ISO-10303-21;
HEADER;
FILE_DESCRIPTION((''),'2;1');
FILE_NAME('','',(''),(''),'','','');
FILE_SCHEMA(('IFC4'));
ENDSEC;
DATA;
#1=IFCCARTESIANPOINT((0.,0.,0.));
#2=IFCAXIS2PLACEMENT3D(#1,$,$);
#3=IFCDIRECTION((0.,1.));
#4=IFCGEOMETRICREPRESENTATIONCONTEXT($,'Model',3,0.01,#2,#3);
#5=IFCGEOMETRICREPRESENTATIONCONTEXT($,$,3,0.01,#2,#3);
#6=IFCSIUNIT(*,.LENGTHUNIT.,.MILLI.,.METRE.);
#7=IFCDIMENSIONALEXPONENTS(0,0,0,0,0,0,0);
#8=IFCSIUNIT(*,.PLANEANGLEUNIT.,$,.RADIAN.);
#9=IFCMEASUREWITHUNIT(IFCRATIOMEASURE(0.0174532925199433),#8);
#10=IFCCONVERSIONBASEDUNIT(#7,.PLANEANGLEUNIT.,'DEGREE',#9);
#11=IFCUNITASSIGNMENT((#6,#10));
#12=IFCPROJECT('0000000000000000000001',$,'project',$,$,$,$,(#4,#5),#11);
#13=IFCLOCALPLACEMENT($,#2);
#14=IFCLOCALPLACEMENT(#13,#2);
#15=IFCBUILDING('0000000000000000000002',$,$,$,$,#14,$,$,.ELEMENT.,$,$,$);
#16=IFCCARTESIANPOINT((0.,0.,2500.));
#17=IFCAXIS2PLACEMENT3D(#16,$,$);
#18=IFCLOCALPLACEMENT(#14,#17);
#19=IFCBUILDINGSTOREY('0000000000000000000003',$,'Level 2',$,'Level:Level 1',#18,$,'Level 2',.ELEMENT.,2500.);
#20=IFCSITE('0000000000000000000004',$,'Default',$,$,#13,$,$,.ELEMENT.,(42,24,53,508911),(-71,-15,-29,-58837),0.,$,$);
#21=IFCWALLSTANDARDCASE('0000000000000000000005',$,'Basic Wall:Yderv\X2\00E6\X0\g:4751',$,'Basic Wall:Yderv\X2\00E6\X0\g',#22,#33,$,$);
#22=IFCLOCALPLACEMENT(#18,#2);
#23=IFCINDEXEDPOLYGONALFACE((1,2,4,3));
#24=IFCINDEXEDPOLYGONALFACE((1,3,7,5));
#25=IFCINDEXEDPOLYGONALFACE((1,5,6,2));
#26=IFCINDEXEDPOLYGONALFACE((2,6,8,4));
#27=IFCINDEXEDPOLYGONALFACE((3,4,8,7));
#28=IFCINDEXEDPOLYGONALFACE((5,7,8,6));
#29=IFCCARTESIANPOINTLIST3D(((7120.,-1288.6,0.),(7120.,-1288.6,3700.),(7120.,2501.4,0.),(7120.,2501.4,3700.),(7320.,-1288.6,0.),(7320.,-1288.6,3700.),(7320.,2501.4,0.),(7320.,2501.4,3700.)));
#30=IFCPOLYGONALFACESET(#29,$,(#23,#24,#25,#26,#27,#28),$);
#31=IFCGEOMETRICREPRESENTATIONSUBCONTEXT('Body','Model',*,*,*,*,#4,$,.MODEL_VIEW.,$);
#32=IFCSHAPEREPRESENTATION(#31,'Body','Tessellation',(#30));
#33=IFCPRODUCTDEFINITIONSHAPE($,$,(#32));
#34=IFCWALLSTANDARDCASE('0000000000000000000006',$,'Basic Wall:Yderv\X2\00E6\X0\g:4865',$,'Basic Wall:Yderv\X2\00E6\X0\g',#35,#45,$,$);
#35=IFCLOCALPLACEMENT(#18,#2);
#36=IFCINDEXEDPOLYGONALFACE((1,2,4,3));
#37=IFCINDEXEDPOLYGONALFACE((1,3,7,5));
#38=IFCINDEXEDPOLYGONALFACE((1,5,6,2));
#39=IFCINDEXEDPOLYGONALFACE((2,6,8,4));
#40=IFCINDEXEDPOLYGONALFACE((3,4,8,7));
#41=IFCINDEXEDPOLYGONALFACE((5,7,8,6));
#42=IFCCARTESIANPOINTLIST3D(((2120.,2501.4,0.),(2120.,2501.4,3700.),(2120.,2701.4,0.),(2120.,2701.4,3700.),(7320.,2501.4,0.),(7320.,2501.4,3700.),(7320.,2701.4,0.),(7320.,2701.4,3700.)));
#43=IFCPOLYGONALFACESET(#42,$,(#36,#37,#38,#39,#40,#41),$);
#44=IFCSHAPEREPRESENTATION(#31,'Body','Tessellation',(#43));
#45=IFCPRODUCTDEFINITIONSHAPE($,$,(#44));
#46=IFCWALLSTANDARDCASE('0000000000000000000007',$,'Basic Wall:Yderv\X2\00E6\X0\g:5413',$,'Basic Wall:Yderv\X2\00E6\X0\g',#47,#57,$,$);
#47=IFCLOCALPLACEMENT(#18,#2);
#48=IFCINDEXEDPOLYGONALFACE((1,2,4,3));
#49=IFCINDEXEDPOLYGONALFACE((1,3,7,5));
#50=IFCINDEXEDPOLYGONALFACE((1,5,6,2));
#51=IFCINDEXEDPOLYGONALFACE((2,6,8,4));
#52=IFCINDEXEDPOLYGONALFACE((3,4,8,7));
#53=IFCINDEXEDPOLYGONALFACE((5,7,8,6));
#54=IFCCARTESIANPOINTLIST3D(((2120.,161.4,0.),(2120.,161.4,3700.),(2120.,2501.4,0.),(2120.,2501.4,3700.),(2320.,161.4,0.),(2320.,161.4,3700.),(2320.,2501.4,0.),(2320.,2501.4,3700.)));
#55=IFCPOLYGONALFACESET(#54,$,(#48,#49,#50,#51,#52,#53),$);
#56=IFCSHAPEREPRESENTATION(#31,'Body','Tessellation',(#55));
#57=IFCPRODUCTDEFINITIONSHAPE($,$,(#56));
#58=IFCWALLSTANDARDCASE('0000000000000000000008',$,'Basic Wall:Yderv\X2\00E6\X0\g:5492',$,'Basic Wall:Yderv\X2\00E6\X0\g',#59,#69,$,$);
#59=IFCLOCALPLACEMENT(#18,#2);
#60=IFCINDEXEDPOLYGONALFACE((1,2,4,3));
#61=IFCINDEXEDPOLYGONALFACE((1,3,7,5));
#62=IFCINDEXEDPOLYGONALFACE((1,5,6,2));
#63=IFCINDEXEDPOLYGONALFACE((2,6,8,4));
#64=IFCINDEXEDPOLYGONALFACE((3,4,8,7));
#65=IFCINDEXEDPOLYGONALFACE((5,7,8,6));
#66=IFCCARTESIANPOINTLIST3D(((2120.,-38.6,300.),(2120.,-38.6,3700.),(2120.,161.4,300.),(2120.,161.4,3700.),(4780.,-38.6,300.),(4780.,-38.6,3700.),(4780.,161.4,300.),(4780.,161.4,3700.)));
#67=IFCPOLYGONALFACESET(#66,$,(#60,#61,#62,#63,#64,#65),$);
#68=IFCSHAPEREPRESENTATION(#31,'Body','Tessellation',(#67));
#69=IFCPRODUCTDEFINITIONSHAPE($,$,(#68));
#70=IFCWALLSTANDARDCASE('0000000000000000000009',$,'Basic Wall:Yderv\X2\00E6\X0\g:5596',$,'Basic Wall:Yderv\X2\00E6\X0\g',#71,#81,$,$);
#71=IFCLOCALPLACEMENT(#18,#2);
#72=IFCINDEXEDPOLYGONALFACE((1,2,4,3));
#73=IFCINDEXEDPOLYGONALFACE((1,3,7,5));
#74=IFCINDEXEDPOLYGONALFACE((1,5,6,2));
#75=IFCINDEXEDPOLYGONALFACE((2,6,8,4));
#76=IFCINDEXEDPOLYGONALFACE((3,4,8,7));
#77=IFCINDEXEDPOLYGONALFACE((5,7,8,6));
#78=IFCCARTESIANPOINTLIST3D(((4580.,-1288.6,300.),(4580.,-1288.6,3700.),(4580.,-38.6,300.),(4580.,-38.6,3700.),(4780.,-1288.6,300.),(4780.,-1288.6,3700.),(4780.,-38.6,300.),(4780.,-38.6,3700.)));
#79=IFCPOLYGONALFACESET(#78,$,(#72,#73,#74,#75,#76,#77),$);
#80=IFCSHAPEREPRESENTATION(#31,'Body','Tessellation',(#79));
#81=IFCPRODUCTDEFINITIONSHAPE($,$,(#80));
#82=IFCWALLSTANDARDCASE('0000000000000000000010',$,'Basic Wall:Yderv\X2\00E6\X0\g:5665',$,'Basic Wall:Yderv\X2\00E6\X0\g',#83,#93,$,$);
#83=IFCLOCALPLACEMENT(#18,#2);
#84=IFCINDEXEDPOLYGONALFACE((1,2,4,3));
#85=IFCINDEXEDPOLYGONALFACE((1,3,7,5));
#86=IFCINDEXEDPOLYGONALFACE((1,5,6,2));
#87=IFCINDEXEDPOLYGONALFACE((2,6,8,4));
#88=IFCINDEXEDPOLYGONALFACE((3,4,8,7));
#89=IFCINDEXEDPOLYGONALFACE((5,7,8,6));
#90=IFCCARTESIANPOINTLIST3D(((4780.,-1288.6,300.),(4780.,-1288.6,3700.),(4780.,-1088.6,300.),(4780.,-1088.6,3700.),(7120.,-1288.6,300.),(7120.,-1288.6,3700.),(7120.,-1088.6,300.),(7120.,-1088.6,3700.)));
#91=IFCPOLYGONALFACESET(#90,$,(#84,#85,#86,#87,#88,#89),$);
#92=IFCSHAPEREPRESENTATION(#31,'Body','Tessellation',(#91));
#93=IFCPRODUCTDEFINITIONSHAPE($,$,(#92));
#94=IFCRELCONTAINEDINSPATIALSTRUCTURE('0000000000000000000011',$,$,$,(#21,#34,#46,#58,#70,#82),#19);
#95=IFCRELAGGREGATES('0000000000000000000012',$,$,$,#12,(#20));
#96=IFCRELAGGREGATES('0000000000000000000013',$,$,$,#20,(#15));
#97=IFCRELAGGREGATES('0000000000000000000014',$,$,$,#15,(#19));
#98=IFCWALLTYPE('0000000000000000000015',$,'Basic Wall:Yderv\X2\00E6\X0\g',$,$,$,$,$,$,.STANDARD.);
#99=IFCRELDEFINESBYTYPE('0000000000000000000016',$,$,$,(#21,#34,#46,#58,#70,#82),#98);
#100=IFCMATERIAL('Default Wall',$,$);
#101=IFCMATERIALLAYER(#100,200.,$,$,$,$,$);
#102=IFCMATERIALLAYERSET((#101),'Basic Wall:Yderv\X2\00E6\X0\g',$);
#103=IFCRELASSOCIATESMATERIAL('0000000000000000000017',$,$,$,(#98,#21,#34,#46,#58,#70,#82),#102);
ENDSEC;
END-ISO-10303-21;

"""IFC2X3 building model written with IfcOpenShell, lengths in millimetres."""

from ifc_helpers import new_model, entity, si_unit, converted_unit, direction, frame, frame_2d, origin, place, context, subcontext, project, spatial, rectangle, extrude, material, layer, layer_set, layer_usage, type_object, element, save


model = new_model("IFC2X3")

# Units and contexts
model_context = context("Model", 3, precision=0.01, world=origin(), true_north=direction((0.0, 1.0)))
context_of_model = context(None, 3, precision=0.01, world=origin(), true_north=direction((0.0, 1.0)))
body_context = subcontext(model_context, "Body", "Model", "MODEL_VIEW")
ifc_project = project(units=[si_unit("LENGTHUNIT", "METRE", prefix="MILLI"), converted_unit("PLANEANGLEUNIT", "DEGREE", entity("IfcRatioMeasure", 0.0174532925199433), si_unit("PLANEANGLEUNIT", "RADIAN"), dimensions=[0, 0, 0, 0, 0, 0, 0])], contexts=[model_context, context_of_model])

# Site, building, storey
site_placement = place(None, origin())
site = spatial("IfcSite", under=ifc_project, at=site_placement, Name="Default", CompositionType="ELEMENT", RefLatitude=(42, 24, 53, 508911), RefLongitude=(-71, -15, -29, -58837), RefElevation=0.0)
building_placement = place(site_placement, origin())
building = spatial("IfcBuilding", under=site, at=building_placement, CompositionType="ELEMENT")
storey_placement = place(building_placement, frame((0.0, 0.0, 2500.0)))
storey = spatial("IfcBuildingStorey", under=building, at=storey_placement, Name="Level 2", ObjectType="Level:Level 1", LongName="Level 2", CompositionType="ELEMENT", Elevation=2500.0)

# Walls
ifc_material_1 = material(Name="Default Wall")
ifc_layer_1 = layer(ifc_material_1, 200.0)
ifc_layer_set_1 = layer_set([ifc_layer_1], Name="Basic Wall:Ydervæg")
ifc_layer_usage_1 = layer_usage(ifc_layer_set_1, "AXIS2", "NEGATIVE", 100.0)
wall_type = type_object("IfcWallType", Name="Basic Wall:Ydervæg", PredefinedType="STANDARD", material=ifc_layer_set_1)
wall_1_placement = place(storey_placement, frame((7220.0, 2501.4, 0.0), z_axis=(0.0, 0.0, 1.0), x_axis=(0.0, -1.0, 0.0)))
element("IfcWallStandardCase", 1, at=wall_1_placement, inside=storey, type_object=wall_type, material=ifc_layer_usage_1, Name="Basic Wall:Ydervæg:4751", ObjectType="Basic Wall:Ydervæg", context=body_context, shape_type="SweptSolid", body=[
    extrude(rectangle(XDim=3790.0, YDim=200.0, at=frame_2d((1895.0, 0.0), x_axis=(-1.0, 0.0))), origin(), (0.0, 0.0, 1.0), 3700.0),
])
ifc_layer_usage_2 = layer_usage(ifc_layer_set_1, "AXIS2", "NEGATIVE", 100.0)
wall_2_placement = place(storey_placement, frame((2120.0, 2601.4, 0.0)))
element("IfcWallStandardCase", 2, at=wall_2_placement, inside=storey, type_object=wall_type, material=ifc_layer_usage_2, Name="Basic Wall:Ydervæg:4865", ObjectType="Basic Wall:Ydervæg", context=body_context, shape_type="SweptSolid", body=[
    extrude(rectangle(XDim=5200.0, YDim=200.0, at=frame_2d((2600.0, 0.0), x_axis=(-1.0, 0.0))), origin(), (0.0, 0.0, 1.0), 3700.0),
])
ifc_layer_usage_3 = layer_usage(ifc_layer_set_1, "AXIS2", "NEGATIVE", 100.0)
wall_3_placement = place(storey_placement, frame((2220.0, 2501.4, 0.0), z_axis=(0.0, 0.0, 1.0), x_axis=(0.0, -1.0, 0.0)))
element("IfcWallStandardCase", 3, at=wall_3_placement, inside=storey, type_object=wall_type, material=ifc_layer_usage_3, Name="Basic Wall:Ydervæg:5413", ObjectType="Basic Wall:Ydervæg", context=body_context, shape_type="SweptSolid", body=[
    extrude(rectangle(XDim=2340.0, YDim=200.0, at=frame_2d((1170.0, 0.0), x_axis=(-1.0, 0.0))), origin(), (0.0, 0.0, 1.0), 3700.0),
])
ifc_layer_usage_4 = layer_usage(ifc_layer_set_1, "AXIS2", "NEGATIVE", 100.0)
wall_4_placement = place(storey_placement, frame((2120.0, 61.4, 300.0)))
element("IfcWallStandardCase", 4, at=wall_4_placement, inside=storey, type_object=wall_type, material=ifc_layer_usage_4, Name="Basic Wall:Ydervæg:5492", ObjectType="Basic Wall:Ydervæg", context=body_context, shape_type="SweptSolid", body=[
    extrude(rectangle(XDim=2660.0, YDim=200.0, at=frame_2d((1330.0, 0.0), x_axis=(-1.0, 0.0))), origin(), (0.0, 0.0, 1.0), 3400.0),
])
ifc_layer_usage_5 = layer_usage(ifc_layer_set_1, "AXIS2", "NEGATIVE", 100.0)
wall_5_placement = place(storey_placement, frame((4680.0, -38.6, 300.0), z_axis=(0.0, 0.0, 1.0), x_axis=(0.0, -1.0, 0.0)))
element("IfcWallStandardCase", 5, at=wall_5_placement, inside=storey, type_object=wall_type, material=ifc_layer_usage_5, Name="Basic Wall:Ydervæg:5596", ObjectType="Basic Wall:Ydervæg", context=body_context, shape_type="SweptSolid", body=[
    extrude(rectangle(XDim=1250.0, YDim=200.0, at=frame_2d((625.0, 0.0), x_axis=(-1.0, 0.0))), origin(), (0.0, 0.0, 1.0), 3400.0),
])
ifc_layer_usage_6 = layer_usage(ifc_layer_set_1, "AXIS2", "NEGATIVE", 100.0)
wall_6_placement = place(storey_placement, frame((4780.0, -1188.6, 300.0)))
element("IfcWallStandardCase", 6, at=wall_6_placement, inside=storey, type_object=wall_type, material=ifc_layer_usage_6, Name="Basic Wall:Ydervæg:5665", ObjectType="Basic Wall:Ydervæg", context=body_context, shape_type="SweptSolid", body=[
    extrude(rectangle(XDim=2340.0, YDim=200.0, at=frame_2d((1170.0, 0.0), x_axis=(-1.0, 0.0))), origin(), (0.0, 0.0, 1.0), 3400.0),
])

save(model, "model.ifc")
